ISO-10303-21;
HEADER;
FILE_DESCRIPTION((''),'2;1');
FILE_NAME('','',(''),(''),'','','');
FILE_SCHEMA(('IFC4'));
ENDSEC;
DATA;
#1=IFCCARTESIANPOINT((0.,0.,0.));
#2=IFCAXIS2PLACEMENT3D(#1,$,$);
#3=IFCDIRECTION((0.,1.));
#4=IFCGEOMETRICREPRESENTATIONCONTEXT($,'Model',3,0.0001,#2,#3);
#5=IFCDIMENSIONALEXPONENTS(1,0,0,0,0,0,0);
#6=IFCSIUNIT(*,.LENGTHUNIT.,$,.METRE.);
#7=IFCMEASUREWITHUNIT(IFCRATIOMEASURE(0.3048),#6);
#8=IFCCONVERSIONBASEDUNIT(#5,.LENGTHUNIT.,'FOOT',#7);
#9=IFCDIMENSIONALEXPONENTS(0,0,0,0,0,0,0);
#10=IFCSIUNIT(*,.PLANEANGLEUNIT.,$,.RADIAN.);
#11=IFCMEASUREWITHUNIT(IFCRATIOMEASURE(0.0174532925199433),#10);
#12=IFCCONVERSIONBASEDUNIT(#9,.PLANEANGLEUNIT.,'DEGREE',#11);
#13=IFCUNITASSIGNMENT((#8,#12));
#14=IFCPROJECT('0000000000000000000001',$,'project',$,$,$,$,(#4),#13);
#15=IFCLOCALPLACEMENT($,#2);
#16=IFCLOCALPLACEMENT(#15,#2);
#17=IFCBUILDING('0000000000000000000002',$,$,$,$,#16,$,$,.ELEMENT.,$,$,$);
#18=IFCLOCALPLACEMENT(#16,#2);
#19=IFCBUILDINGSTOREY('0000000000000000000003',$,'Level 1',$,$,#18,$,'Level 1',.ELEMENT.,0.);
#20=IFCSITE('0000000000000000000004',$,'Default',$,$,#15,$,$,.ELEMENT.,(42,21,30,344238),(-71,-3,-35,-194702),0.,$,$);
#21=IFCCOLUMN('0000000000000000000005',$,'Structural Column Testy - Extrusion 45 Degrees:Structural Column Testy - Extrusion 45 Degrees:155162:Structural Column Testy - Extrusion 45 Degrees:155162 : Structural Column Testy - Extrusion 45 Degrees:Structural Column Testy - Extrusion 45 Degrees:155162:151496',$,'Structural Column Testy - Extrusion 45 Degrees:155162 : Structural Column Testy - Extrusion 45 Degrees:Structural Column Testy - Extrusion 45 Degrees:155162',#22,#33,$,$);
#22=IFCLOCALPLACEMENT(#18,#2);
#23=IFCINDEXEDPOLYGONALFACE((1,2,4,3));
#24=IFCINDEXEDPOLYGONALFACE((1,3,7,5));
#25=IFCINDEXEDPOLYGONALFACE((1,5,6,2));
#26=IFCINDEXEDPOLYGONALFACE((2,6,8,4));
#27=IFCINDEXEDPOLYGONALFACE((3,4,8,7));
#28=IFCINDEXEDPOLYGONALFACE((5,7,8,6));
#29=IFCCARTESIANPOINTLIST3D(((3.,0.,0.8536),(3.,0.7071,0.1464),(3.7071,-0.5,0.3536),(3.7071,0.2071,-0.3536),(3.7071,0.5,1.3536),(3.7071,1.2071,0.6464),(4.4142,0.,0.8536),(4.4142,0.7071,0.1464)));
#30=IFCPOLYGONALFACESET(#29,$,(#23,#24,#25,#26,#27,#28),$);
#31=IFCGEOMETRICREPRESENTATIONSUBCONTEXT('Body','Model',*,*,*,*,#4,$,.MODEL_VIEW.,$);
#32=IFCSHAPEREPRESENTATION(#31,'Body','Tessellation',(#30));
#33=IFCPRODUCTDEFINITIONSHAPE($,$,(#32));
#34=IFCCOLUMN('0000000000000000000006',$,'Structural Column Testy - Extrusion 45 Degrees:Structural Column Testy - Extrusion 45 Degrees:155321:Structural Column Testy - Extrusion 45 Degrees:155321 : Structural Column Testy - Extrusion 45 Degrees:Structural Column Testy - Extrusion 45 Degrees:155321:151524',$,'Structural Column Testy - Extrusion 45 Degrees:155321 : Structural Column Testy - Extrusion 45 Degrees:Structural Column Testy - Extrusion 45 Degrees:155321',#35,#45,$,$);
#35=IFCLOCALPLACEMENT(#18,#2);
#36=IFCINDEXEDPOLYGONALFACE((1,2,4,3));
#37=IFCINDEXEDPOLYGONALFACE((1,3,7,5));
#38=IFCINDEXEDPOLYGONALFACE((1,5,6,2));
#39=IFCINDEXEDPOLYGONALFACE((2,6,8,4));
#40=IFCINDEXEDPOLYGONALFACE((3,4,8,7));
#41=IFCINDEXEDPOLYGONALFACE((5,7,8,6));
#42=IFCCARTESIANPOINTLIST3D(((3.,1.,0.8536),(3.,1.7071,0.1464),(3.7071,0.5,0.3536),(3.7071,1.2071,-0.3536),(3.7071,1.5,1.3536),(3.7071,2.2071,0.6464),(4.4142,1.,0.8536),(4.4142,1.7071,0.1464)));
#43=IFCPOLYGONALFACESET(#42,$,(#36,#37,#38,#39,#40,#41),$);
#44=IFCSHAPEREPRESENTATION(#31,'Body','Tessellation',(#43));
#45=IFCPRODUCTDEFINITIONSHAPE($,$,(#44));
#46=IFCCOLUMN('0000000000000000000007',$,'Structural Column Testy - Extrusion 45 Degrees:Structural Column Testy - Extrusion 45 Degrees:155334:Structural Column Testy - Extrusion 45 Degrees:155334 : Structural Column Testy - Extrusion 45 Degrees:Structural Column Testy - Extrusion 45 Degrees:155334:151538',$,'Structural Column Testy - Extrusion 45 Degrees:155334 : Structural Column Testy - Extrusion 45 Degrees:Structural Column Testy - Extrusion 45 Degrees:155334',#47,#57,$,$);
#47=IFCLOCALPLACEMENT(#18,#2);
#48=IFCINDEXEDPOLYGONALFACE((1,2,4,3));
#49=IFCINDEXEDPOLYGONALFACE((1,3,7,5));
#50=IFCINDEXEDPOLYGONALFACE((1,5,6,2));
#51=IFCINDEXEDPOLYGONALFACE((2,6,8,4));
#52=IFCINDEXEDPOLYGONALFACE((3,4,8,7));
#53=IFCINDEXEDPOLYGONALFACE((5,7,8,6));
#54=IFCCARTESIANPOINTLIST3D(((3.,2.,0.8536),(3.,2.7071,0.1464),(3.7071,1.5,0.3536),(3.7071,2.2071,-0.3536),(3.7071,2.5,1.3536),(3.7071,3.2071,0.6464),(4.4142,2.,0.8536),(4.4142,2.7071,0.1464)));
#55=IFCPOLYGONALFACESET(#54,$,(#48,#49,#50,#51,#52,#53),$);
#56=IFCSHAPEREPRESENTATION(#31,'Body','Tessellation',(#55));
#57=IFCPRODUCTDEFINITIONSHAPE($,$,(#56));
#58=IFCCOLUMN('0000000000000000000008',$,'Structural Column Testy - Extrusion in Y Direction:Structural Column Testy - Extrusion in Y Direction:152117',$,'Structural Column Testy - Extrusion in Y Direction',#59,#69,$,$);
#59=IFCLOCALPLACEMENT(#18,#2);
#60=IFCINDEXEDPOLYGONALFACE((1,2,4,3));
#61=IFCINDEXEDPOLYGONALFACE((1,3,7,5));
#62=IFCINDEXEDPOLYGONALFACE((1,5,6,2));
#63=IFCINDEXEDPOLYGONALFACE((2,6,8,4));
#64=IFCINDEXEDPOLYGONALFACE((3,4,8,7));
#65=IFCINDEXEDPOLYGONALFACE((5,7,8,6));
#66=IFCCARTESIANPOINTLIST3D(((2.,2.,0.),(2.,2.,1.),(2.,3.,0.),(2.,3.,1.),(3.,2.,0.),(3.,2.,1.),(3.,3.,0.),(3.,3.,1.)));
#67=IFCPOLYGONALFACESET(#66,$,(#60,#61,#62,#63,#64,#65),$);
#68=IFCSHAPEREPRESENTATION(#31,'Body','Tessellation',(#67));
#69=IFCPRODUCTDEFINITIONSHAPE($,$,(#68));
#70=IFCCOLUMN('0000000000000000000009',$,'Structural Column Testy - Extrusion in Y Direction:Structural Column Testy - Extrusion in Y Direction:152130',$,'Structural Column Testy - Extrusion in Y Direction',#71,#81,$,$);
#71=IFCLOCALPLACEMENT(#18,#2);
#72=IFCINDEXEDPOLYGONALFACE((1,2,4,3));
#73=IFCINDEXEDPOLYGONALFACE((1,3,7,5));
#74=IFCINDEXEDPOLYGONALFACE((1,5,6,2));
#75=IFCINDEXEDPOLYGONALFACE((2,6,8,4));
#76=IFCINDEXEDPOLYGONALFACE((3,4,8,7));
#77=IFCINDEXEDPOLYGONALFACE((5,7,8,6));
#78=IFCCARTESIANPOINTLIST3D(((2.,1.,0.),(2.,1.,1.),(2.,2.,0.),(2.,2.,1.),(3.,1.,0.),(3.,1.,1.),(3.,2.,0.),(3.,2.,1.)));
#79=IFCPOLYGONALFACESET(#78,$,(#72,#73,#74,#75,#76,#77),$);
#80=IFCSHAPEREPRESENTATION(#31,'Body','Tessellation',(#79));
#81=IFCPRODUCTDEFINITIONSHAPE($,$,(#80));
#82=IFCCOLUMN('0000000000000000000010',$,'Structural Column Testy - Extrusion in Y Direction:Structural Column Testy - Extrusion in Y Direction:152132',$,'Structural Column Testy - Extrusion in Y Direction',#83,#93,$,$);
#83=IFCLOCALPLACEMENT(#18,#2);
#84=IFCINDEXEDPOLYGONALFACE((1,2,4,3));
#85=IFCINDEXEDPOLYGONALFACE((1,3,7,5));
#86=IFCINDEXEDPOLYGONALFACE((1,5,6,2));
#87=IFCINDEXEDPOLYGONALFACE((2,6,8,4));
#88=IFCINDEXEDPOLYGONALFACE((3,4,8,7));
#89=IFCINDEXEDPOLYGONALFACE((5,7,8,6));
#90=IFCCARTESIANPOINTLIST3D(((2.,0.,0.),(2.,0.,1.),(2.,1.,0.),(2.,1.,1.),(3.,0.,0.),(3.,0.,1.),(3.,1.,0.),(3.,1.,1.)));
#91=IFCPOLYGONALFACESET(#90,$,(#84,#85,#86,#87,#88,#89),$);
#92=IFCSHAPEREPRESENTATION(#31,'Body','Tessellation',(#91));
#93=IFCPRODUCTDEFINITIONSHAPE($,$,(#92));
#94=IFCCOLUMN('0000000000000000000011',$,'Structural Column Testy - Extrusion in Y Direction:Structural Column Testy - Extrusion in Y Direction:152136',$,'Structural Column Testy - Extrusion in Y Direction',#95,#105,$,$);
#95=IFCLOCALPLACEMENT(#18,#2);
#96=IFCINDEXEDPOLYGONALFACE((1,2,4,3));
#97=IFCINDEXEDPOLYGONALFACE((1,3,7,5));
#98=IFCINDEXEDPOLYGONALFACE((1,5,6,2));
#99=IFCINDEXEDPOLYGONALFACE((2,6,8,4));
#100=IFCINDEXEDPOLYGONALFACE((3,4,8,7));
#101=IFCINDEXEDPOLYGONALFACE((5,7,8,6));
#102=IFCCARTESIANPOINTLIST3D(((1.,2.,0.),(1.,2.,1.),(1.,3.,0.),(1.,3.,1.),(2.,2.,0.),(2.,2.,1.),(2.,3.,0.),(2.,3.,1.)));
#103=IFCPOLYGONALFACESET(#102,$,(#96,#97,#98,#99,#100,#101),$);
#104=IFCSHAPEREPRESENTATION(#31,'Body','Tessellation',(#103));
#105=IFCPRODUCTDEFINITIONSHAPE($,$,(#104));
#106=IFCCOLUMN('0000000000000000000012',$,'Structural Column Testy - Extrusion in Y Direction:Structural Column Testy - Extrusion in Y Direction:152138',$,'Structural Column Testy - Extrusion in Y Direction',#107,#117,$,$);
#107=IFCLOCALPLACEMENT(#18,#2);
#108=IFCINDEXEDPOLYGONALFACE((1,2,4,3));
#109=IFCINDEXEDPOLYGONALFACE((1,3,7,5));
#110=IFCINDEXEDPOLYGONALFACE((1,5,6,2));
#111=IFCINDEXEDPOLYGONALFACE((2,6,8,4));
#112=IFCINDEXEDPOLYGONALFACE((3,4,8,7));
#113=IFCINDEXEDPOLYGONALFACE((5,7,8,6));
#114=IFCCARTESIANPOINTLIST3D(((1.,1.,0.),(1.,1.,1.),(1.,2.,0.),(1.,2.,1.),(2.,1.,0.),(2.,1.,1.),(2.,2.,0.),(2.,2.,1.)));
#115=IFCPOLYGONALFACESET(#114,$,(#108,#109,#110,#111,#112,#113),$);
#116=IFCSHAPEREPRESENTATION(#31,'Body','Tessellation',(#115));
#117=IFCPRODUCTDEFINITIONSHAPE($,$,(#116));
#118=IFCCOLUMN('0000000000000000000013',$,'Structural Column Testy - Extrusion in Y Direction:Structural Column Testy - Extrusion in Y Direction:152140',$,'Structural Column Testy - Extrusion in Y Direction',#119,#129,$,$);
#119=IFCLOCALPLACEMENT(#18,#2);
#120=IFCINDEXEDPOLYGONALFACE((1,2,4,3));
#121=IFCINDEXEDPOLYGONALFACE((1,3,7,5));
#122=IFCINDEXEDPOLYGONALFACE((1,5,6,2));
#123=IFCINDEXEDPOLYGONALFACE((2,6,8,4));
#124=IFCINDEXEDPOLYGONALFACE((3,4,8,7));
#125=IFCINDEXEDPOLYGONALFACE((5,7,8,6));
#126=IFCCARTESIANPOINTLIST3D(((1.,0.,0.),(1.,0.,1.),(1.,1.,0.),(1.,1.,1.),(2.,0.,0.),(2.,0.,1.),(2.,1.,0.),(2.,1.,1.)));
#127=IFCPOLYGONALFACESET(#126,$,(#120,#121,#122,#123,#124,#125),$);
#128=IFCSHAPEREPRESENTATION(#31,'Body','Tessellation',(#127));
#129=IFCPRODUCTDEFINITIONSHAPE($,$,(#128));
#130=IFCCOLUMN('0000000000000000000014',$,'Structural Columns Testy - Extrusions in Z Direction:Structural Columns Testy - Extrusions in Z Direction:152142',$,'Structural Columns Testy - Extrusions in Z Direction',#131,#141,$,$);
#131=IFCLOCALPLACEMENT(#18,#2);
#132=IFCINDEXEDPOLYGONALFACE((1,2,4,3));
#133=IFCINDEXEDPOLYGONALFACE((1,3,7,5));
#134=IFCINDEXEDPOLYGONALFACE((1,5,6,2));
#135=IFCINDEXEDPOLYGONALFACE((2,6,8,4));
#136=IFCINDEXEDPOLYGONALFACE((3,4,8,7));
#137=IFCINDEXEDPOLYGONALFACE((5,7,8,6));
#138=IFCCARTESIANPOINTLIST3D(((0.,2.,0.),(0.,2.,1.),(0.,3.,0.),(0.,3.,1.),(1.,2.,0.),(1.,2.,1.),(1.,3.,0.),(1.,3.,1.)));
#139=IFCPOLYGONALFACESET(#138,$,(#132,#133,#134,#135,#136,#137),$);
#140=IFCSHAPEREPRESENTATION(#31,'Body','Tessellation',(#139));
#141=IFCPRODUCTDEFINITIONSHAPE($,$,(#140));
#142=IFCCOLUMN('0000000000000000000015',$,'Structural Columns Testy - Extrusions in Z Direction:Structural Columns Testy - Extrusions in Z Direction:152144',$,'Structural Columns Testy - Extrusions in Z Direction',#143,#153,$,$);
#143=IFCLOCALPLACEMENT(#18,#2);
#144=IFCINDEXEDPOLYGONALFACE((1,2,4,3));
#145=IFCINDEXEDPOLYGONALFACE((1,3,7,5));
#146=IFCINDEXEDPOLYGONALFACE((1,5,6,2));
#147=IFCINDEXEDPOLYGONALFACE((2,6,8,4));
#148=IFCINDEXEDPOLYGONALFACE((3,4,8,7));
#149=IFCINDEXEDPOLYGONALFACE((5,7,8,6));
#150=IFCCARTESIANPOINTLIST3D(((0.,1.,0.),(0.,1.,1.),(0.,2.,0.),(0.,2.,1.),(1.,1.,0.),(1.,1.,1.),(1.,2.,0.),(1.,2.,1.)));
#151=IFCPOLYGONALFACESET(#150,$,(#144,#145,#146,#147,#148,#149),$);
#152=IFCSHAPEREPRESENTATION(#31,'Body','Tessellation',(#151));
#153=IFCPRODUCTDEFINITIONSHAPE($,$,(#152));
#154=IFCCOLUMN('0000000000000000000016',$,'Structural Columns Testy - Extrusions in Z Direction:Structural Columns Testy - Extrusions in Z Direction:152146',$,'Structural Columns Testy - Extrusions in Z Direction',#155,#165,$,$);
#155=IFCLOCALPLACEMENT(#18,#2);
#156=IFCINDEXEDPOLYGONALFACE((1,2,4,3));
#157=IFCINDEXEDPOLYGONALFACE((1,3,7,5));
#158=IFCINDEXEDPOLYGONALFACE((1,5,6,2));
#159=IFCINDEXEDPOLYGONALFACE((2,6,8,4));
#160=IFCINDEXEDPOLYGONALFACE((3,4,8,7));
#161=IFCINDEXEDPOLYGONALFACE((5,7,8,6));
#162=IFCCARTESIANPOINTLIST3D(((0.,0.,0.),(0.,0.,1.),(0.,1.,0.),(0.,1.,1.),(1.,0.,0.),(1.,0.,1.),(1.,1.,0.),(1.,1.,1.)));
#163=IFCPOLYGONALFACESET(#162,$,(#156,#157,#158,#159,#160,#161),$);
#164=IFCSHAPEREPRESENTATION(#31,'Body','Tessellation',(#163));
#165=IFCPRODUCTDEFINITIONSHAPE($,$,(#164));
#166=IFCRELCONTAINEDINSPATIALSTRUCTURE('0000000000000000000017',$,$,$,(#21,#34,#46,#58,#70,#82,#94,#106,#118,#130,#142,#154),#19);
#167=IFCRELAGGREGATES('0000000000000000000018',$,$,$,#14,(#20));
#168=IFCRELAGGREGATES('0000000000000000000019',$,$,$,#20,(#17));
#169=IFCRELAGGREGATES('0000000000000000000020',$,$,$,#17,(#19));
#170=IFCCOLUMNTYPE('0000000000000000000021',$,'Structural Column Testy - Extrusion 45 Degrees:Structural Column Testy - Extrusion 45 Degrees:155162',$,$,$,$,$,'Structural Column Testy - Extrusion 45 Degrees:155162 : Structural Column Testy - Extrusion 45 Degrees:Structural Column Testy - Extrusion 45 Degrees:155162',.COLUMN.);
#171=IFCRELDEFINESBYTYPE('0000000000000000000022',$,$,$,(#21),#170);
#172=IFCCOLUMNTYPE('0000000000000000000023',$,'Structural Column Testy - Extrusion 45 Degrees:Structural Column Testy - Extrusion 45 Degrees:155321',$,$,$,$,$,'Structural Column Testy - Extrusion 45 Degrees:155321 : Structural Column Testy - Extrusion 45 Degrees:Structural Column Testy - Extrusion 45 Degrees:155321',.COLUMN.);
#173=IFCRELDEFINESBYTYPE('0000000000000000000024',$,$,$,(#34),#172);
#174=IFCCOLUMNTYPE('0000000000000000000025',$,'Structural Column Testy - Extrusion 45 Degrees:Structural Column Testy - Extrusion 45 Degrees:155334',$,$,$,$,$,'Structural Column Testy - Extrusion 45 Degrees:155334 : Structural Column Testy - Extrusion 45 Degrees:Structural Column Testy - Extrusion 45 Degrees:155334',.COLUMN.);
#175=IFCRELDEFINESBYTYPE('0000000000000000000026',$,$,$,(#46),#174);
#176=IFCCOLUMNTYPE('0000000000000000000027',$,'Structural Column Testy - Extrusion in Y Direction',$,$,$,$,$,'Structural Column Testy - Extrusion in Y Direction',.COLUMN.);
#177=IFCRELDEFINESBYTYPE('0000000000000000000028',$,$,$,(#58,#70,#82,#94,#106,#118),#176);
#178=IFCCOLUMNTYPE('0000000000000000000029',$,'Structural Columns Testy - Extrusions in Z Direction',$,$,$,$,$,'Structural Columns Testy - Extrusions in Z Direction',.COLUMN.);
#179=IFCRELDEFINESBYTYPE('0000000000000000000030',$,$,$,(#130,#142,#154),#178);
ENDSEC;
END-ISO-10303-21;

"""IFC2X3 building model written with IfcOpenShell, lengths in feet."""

from ifc_helpers import new_model, entity, si_unit, converted_unit, direction, frame, frame_2d, origin, origin_2d_with_axis, place, context, subcontext, project, spatial, rectangle, extrude, source, transform, mapped, type_object, type_shapes, element, save


model = new_model("IFC2X3")

# Units and contexts
model_context = context("Model", 3, precision=0.0001, world=origin(), true_north=direction((0.0, 1.0)))
body_context = subcontext(model_context, "Body", "Model", "MODEL_VIEW")
ifc_project = project(units=[converted_unit("LENGTHUNIT", "FOOT", entity("IfcRatioMeasure", 0.3048), si_unit("LENGTHUNIT", "METRE"), dimensions=[1, 0, 0, 0, 0, 0, 0]), converted_unit("PLANEANGLEUNIT", "DEGREE", entity("IfcRatioMeasure", 0.0174532925199433), si_unit("PLANEANGLEUNIT", "RADIAN"), dimensions=[0, 0, 0, 0, 0, 0, 0])], contexts=[model_context])

# Site, building, storey
site_placement = place(None, origin())
site = spatial("IfcSite", under=ifc_project, at=site_placement, Name="Default", CompositionType="ELEMENT", RefLatitude=(42, 21, 30, 344238), RefLongitude=(-71, -3, -35, -194702), RefElevation=0.0)
building_placement = place(site_placement, origin())
building = spatial("IfcBuilding", under=site, at=building_placement, CompositionType="ELEMENT")
storey_placement = place(building_placement, origin())
storey = spatial("IfcBuildingStorey", under=building, at=storey_placement, Name="Level 1", LongName="Level 1", CompositionType="ELEMENT", Elevation=0.0)

# Columns
column_type_1 = type_object("IfcColumnType", Name="Structural Column Testy - Extrusion 45 Degrees:Structural Column Testy - Extrusion 45 Degrees:155162", ElementType="Structural Column Testy - Extrusion 45 Degrees:155162 : Structural Column Testy - Extrusion 45 Degrees:Structural Column Testy - Extrusion 45 Degrees:155162", PredefinedType="COLUMN")
shared_shape_1 = source(origin(), body_context, "Body", "SweptSolid", [
    extrude(rectangle(XDim=1.0, YDim=1.0, at=frame_2d((0.0, 0.0), x_axis=(1.0, 0.0))), frame((3.7071, 0.7071, 0.1464), z_axis=(0.0, -0.707107, 0.707107), x_axis=(-0.707107, -0.5, -0.5)), (0.0, 0.0, 1.0), 1.0),
])
type_shapes(column_type_1, [shared_shape_1])
column_1_placement = place(storey_placement, origin())
element("IfcColumn", 1, at=column_1_placement, inside=storey, type_object=column_type_1, Name="Structural Column Testy - Extrusion 45 Degrees:Structural Column Testy - Extrusion 45 Degrees:155162:Structural Column Testy - Extrusion 45 Degrees:155162 : Structural Column Testy - Extrusion 45 Degrees:Structural Column Testy - Extrusion 45 Degrees:155162:151496", ObjectType="Structural Column Testy - Extrusion 45 Degrees:155162 : Structural Column Testy - Extrusion 45 Degrees:Structural Column Testy - Extrusion 45 Degrees:155162", context=body_context, shape_type="MappedRepresentation", body=[
    mapped(shared_shape_1, transform((0.0, 0.0, 0.0), scale=1.0)),
])
column_type_2 = type_object("IfcColumnType", Name="Structural Column Testy - Extrusion 45 Degrees:Structural Column Testy - Extrusion 45 Degrees:155321", ElementType="Structural Column Testy - Extrusion 45 Degrees:155321 : Structural Column Testy - Extrusion 45 Degrees:Structural Column Testy - Extrusion 45 Degrees:155321", PredefinedType="COLUMN")
shared_shape_2 = source(origin(), body_context, "Body", "SweptSolid", [
    extrude(rectangle(XDim=1.0, YDim=1.0, at=frame_2d((0.0, 0.0), x_axis=(1.0, 0.0))), frame((3.7071, 1.7071, 0.1464), z_axis=(0.0, -0.707107, 0.707107), x_axis=(-0.707107, -0.5, -0.5)), (0.0, 0.0, 1.0), 1.0),
])
type_shapes(column_type_2, [shared_shape_2])
column_2_placement = place(storey_placement, origin())
element("IfcColumn", 2, at=column_2_placement, inside=storey, type_object=column_type_2, Name="Structural Column Testy - Extrusion 45 Degrees:Structural Column Testy - Extrusion 45 Degrees:155321:Structural Column Testy - Extrusion 45 Degrees:155321 : Structural Column Testy - Extrusion 45 Degrees:Structural Column Testy - Extrusion 45 Degrees:155321:151524", ObjectType="Structural Column Testy - Extrusion 45 Degrees:155321 : Structural Column Testy - Extrusion 45 Degrees:Structural Column Testy - Extrusion 45 Degrees:155321", context=body_context, shape_type="MappedRepresentation", body=[
    mapped(shared_shape_2, transform((0.0, 0.0, 0.0), scale=1.0)),
])
column_type_3 = type_object("IfcColumnType", Name="Structural Column Testy - Extrusion 45 Degrees:Structural Column Testy - Extrusion 45 Degrees:155334", ElementType="Structural Column Testy - Extrusion 45 Degrees:155334 : Structural Column Testy - Extrusion 45 Degrees:Structural Column Testy - Extrusion 45 Degrees:155334", PredefinedType="COLUMN")
shared_shape_3 = source(origin(), body_context, "Body", "SweptSolid", [
    extrude(rectangle(XDim=1.0, YDim=1.0, at=frame_2d((0.0, 0.0), x_axis=(1.0, 0.0))), frame((3.7071, 2.7071, 0.1464), z_axis=(0.0, -0.707107, 0.707107), x_axis=(-0.707107, -0.5, -0.5)), (0.0, 0.0, 1.0), 1.0),
])
type_shapes(column_type_3, [shared_shape_3])
column_3_placement = place(storey_placement, origin())
element("IfcColumn", 3, at=column_3_placement, inside=storey, type_object=column_type_3, Name="Structural Column Testy - Extrusion 45 Degrees:Structural Column Testy - Extrusion 45 Degrees:155334:Structural Column Testy - Extrusion 45 Degrees:155334 : Structural Column Testy - Extrusion 45 Degrees:Structural Column Testy - Extrusion 45 Degrees:155334:151538", ObjectType="Structural Column Testy - Extrusion 45 Degrees:155334 : Structural Column Testy - Extrusion 45 Degrees:Structural Column Testy - Extrusion 45 Degrees:155334", context=body_context, shape_type="MappedRepresentation", body=[
    mapped(shared_shape_3, transform((0.0, 0.0, 0.0), scale=1.0)),
])
column_type_4 = type_object("IfcColumnType", Name="Structural Column Testy - Extrusion in Y Direction", ElementType="Structural Column Testy - Extrusion in Y Direction", PredefinedType="COLUMN")
shared_shape_4 = source(origin(), body_context, "Body", "SweptSolid", [
    extrude(rectangle(XDim=1.0, YDim=1.0, at=origin_2d_with_axis()), frame((0.5, -0.5, 0.0), z_axis=(0.0, 0.0, 1.0), x_axis=(0.0, -1.0, 0.0)), (0.0, 0.0, 1.0), 1.0),
])
type_shapes(column_type_4, [shared_shape_4])
for number, where, name in (
    (4, (2.0, 3.0, 0.0), "Structural Column Testy - Extrusion in Y Direction:Structural Column Testy - Extrusion in Y Direction:152117"),
    (5, (2.0, 2.0, 0.0), "Structural Column Testy - Extrusion in Y Direction:Structural Column Testy - Extrusion in Y Direction:152130"),
    (6, (2.0, 1.0, 0.0), "Structural Column Testy - Extrusion in Y Direction:Structural Column Testy - Extrusion in Y Direction:152132"),
    (7, (1.0, 3.0, 0.0), "Structural Column Testy - Extrusion in Y Direction:Structural Column Testy - Extrusion in Y Direction:152136"),
    (8, (1.0, 2.0, 0.0), "Structural Column Testy - Extrusion in Y Direction:Structural Column Testy - Extrusion in Y Direction:152138"),
    (9, (1.0, 1.0, 0.0), "Structural Column Testy - Extrusion in Y Direction:Structural Column Testy - Extrusion in Y Direction:152140"),
):
    element("IfcColumn", number, at=place(storey_placement, frame(where)), inside=storey, type_object=column_type_4, Name=name, ObjectType="Structural Column Testy - Extrusion in Y Direction", context=body_context, shape_type="MappedRepresentation", body=[
        mapped(shared_shape_4, transform((0.0, 0.0, 0.0), scale=1.0)),
    ])
column_type_5 = type_object("IfcColumnType", Name="Structural Columns Testy - Extrusions in Z Direction", ElementType="Structural Columns Testy - Extrusions in Z Direction", PredefinedType="COLUMN")
shared_shape_5 = source(origin(), body_context, "Body", "SweptSolid", [
    extrude(rectangle(XDim=1.0, YDim=1.0, at=frame_2d((0.0, 0.0), x_axis=(1.0, 0.0))), frame((0.5, 0.5, 0.0), z_axis=(0.0, 0.0, 1.0), x_axis=(0.0, -1.0, 0.0)), (0.0, 0.0, 1.0), 1.0),
])
type_shapes(column_type_5, [shared_shape_5])
for number, where, name in (
    (10, (0.0, 2.0, 0.0), "Structural Columns Testy - Extrusions in Z Direction:Structural Columns Testy - Extrusions in Z Direction:152142"),
    (11, (0.0, 1.0, 0.0), "Structural Columns Testy - Extrusions in Z Direction:Structural Columns Testy - Extrusions in Z Direction:152144"),
    (12, (0.0, 0.0, 0.0), "Structural Columns Testy - Extrusions in Z Direction:Structural Columns Testy - Extrusions in Z Direction:152146"),
):
    element("IfcColumn", number, at=place(storey_placement, frame(where)), inside=storey, type_object=column_type_5, Name=name, ObjectType="Structural Columns Testy - Extrusions in Z Direction", context=body_context, shape_type="MappedRepresentation", body=[
        mapped(shared_shape_5, transform((0.0, 0.0, 0.0), scale=1.0)),
    ])

save(model, "model.ifc")
